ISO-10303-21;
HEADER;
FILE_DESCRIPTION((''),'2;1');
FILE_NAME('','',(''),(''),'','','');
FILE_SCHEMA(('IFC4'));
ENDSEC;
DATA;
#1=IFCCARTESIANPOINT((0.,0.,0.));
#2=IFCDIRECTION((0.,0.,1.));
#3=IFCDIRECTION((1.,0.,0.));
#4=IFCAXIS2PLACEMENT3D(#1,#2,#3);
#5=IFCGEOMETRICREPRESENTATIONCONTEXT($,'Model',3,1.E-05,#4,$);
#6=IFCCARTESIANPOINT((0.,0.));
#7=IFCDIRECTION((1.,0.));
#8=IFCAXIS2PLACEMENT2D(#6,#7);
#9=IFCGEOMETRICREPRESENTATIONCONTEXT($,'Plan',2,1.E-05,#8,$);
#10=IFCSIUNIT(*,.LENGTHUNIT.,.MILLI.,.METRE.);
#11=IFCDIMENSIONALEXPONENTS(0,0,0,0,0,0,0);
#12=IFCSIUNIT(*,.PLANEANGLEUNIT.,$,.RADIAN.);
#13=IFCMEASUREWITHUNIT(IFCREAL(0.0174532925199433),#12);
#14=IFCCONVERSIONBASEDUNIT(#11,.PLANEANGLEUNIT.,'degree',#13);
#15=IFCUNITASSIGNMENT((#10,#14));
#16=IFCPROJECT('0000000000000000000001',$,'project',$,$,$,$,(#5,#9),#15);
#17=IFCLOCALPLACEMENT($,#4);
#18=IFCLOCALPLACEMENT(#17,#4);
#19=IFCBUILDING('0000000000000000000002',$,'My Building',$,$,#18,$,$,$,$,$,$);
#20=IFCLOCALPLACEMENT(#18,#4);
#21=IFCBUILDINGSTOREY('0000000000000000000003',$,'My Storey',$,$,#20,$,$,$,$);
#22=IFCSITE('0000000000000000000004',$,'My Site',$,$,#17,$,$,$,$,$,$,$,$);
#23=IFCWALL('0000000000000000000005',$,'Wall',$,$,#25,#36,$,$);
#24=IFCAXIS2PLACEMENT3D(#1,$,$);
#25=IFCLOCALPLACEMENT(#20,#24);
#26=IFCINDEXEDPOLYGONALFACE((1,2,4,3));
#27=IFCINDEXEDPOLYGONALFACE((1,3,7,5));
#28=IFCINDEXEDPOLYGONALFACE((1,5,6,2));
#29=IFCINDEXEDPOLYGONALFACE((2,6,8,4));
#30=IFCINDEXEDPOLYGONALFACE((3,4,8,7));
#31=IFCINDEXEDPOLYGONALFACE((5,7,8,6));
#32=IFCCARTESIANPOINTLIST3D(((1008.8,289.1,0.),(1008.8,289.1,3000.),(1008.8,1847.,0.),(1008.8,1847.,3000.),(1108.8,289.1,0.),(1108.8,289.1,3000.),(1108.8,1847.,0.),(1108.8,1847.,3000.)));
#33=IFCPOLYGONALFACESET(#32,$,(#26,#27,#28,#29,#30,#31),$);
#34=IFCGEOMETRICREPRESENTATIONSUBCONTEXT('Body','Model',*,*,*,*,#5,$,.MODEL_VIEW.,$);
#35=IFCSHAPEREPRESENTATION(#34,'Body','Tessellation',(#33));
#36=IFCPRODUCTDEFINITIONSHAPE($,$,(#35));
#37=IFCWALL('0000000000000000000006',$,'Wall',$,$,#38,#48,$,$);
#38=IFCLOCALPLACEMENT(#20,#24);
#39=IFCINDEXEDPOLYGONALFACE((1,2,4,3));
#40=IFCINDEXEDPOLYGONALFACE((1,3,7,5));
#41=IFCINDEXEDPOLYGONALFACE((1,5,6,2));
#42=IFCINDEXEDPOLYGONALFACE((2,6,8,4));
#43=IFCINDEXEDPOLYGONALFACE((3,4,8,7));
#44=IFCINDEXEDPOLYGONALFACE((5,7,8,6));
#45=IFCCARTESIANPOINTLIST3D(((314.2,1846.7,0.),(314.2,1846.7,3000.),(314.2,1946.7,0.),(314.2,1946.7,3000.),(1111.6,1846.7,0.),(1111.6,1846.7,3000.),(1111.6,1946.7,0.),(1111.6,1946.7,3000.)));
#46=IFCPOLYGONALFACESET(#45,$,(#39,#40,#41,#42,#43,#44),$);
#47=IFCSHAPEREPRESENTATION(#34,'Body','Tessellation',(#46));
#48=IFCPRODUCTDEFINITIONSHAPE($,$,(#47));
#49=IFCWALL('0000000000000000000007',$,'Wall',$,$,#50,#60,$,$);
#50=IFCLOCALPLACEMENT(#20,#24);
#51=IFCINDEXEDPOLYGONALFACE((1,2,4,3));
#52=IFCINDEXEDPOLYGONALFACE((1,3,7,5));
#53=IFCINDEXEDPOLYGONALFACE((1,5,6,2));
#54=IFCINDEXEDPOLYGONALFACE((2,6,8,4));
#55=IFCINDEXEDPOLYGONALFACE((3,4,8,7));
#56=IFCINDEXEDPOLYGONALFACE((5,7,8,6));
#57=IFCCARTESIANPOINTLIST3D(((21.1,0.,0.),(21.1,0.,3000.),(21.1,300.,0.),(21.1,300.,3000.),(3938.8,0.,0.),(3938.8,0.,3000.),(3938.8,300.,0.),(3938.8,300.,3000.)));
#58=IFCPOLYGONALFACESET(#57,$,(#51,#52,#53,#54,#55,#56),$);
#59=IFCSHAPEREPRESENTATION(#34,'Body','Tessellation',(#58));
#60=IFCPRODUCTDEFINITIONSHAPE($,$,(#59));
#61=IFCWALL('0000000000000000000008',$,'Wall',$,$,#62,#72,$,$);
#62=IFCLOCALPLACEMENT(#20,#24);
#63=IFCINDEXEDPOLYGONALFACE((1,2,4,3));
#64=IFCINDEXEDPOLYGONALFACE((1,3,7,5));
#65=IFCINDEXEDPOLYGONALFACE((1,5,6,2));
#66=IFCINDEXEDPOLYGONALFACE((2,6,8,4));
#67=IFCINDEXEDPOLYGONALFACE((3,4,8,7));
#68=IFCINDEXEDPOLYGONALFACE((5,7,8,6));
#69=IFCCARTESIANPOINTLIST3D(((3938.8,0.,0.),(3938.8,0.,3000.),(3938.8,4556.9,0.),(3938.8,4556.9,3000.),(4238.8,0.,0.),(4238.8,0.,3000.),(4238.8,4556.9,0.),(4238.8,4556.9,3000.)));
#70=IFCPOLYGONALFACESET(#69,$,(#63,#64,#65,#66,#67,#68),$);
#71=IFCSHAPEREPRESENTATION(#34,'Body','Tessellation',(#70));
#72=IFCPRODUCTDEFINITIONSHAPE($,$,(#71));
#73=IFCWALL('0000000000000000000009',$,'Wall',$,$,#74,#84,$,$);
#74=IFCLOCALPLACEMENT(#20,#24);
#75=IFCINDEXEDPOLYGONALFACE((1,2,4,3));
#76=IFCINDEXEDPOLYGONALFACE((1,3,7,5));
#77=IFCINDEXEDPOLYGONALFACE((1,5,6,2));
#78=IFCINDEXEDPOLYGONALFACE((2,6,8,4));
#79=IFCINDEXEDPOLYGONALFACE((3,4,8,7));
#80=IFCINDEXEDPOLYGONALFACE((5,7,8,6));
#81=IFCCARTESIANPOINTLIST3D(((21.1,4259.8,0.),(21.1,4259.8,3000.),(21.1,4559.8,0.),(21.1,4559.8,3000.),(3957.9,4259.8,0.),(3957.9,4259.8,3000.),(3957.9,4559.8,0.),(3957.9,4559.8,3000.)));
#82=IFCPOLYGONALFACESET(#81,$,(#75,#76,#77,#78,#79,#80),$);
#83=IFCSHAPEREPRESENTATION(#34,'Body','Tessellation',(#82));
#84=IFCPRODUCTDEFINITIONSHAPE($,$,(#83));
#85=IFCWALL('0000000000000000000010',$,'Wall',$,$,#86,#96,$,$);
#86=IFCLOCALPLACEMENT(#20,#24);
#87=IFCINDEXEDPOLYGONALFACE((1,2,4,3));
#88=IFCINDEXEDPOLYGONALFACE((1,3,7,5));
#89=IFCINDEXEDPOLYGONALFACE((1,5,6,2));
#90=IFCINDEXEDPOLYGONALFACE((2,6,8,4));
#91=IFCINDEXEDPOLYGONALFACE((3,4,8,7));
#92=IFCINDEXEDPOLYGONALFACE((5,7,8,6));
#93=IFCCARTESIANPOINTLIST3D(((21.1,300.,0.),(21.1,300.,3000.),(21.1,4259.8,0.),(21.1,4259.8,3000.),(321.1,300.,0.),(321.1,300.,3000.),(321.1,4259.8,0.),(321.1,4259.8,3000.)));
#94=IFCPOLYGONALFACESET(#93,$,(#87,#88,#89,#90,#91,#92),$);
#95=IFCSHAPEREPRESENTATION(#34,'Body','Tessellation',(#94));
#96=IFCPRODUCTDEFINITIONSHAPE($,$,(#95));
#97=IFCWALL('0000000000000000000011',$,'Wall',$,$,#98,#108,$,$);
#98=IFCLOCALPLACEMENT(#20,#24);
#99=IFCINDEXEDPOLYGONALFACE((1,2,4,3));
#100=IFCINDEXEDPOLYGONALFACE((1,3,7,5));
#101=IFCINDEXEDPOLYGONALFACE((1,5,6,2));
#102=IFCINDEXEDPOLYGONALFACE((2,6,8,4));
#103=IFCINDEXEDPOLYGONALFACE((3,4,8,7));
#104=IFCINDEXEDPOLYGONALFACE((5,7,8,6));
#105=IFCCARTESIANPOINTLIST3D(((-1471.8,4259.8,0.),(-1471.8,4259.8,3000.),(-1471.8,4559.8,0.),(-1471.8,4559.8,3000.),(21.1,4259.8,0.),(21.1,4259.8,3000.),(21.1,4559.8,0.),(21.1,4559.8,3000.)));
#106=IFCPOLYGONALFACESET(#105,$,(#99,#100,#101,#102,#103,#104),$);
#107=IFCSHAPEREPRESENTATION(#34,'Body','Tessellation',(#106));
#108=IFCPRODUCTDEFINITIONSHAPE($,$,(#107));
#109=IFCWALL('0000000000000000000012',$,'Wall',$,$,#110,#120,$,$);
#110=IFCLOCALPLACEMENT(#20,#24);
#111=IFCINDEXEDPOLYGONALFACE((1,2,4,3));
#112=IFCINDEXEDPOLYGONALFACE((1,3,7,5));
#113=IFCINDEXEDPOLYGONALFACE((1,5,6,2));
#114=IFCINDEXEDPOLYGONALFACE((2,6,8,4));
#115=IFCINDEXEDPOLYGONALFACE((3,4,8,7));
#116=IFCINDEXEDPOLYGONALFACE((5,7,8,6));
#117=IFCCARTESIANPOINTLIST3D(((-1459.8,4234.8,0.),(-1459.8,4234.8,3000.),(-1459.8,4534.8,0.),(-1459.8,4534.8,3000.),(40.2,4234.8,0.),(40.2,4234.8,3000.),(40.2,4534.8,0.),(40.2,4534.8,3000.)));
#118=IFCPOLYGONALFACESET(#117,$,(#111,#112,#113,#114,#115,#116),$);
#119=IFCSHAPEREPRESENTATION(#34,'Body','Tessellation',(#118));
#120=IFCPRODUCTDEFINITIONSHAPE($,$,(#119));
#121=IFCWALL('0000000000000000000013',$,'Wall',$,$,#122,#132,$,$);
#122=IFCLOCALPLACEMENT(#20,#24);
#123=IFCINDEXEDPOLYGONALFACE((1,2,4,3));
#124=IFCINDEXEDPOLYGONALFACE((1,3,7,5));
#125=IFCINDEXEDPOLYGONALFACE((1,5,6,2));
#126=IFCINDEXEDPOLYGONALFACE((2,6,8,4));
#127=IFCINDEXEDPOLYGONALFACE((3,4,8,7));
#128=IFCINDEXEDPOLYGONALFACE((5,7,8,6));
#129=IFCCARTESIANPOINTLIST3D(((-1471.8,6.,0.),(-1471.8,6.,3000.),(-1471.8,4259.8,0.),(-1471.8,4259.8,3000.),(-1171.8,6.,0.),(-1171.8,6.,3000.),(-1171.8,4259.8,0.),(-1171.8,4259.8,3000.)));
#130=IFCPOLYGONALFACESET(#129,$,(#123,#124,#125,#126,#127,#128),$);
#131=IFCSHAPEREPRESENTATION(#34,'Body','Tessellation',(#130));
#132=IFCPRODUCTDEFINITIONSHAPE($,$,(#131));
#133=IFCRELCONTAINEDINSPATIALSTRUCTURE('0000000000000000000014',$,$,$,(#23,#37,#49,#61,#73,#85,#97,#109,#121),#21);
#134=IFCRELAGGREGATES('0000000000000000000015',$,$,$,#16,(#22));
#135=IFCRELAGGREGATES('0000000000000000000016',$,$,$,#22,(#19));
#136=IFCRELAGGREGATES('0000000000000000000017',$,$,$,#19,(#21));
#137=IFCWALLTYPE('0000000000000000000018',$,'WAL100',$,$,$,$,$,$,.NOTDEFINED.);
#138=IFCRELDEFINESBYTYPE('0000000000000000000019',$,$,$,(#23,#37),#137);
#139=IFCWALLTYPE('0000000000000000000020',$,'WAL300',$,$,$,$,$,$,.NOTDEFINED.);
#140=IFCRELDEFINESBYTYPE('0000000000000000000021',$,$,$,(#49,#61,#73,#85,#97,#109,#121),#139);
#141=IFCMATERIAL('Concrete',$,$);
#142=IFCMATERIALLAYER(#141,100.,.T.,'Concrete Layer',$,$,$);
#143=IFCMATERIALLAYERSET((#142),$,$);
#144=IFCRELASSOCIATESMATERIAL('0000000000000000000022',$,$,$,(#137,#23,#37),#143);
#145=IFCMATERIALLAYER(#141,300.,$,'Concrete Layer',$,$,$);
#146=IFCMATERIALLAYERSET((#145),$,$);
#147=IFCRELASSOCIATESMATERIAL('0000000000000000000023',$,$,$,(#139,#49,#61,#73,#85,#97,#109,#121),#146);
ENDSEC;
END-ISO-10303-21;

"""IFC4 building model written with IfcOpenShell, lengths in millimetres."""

from ifc_helpers import new_model, entity, si_unit, converted_unit, frame, origin_with_axes, origin_2d_with_axis, place, context, subcontext, project, spatial, indexed_curve, outline, extrude, material, layer, layer_set, layer_usage, type_object, element, save


model = new_model("IFC4")

# Units and contexts
model_context = context("Model", 3, precision=1e-05, world=origin_with_axes())
plan_context = context("Plan", 2, precision=1e-05, world=origin_2d_with_axis())
body_context = subcontext(model_context, "Body", "Model", "MODEL_VIEW")
ifc_project = project(units=[si_unit("LENGTHUNIT", "METRE", prefix="MILLI"), converted_unit("PLANEANGLEUNIT", "degree", entity("IfcReal", 0.0174532925199433), si_unit("PLANEANGLEUNIT", "RADIAN"), dimensions=[0, 0, 0, 0, 0, 0, 0])], contexts=[model_context, plan_context])

# Site, building, storey
site_placement = place(None, origin_with_axes())
site = spatial("IfcSite", under=ifc_project, at=site_placement, Name="My Site")
building_placement = place(site_placement, origin_with_axes())
building = spatial("IfcBuilding", under=site, at=building_placement, Name="My Building")
storey_placement = place(building_placement, origin_with_axes())
storey = spatial("IfcBuildingStorey", under=building, at=storey_placement, Name="My Storey")

# Walls
ifc_material = material(Name="Concrete")
ifc_layer_1 = layer(ifc_material, 100.0, ventilated=True, Name="Concrete Layer")
ifc_layer_set_1 = layer_set([ifc_layer_1])
ifc_layer_usage_1 = layer_usage(ifc_layer_set_1, "AXIS2", "POSITIVE", 0.0)
wall_type_1 = type_object("IfcWallType", Name="WAL100", PredefinedType="NOTDEFINED", material=ifc_layer_set_1)
wall_1_placement = place(storey_placement, frame((1108.8, 289.1, 0.0), z_axis=(0.0, 0.0, 1.0), x_axis=(0.0, 1.0, 0.0)))
element("IfcWall", 1, at=wall_1_placement, inside=storey, type_object=wall_type_1, material=ifc_layer_usage_1, Name="Wall", context=body_context, shape_type="SweptSolid", body=[
    extrude(outline(indexed_curve([(0.0, 0.0), (0.0, 100.0), (1557.9, 100.0), (1557.9, 0.0), (0.0, 0.0)], self_intersect=False)), origin_with_axes(), (0.0, 0.0, 1.0), 3000.0),
])
ifc_layer_usage_2 = layer_usage(ifc_layer_set_1, "AXIS2", "POSITIVE", 0.0)
wall_2_placement = place(storey_placement, frame((1111.6, 1946.7, 0.0), z_axis=(0.0, 0.0, 1.0), x_axis=(-1.0, 0.0, 0.0)))
element("IfcWall", 2, at=wall_2_placement, inside=storey, type_object=wall_type_1, material=ifc_layer_usage_2, Name="Wall", context=body_context, shape_type="SweptSolid", body=[
    extrude(outline(indexed_curve([(0.0, 0.0), (0.0, 100.0), (797.4, 100.0), (797.4, 0.0), (0.0, 0.0)], self_intersect=False)), origin_with_axes(), (0.0, 0.0, 1.0), 3000.0),
])
ifc_layer_2 = layer(ifc_material, 300.0, Name="Concrete Layer")
ifc_layer_set_2 = layer_set([ifc_layer_2])
ifc_layer_usage_3 = layer_usage(ifc_layer_set_2, "AXIS2", "POSITIVE", 0.0)
wall_type_2 = type_object("IfcWallType", Name="WAL300", PredefinedType="NOTDEFINED", material=ifc_layer_set_2)
wall_3_placement = place(storey_placement, frame((21.1, 0.0, 0.0), z_axis=(0.0, 0.0, 1.0), x_axis=(1.0, 0.0, 0.0)))
element("IfcWall", 3, at=wall_3_placement, inside=storey, type_object=wall_type_2, material=ifc_layer_usage_3, Name="Wall", context=body_context, shape_type="SweptSolid", body=[
    extrude(outline(indexed_curve([(0.0, 0.0), (0.0, 300.0), (3917.7, 300.0), (3917.7, 0.0), (0.0, 0.0)], self_intersect=False)), origin_with_axes(), (0.0, 0.0, 1.0), 3000.0),
])
ifc_layer_usage_4 = layer_usage(ifc_layer_set_2, "AXIS2", "POSITIVE", 0.0)
wall_4_placement = place(storey_placement, frame((4238.8, 0.0, 0.0), z_axis=(0.0, 0.0, 1.0), x_axis=(0.0, 1.0, 0.0)))
element("IfcWall", 4, at=wall_4_placement, inside=storey, type_object=wall_type_2, material=ifc_layer_usage_4, Name="Wall", context=body_context, shape_type="SweptSolid", body=[
    extrude(outline(indexed_curve([(0.0, 0.0), (0.0, 300.0), (4556.9, 300.0), (4556.9, 0.0), (0.0, 0.0)], self_intersect=False)), origin_with_axes(), (0.0, 0.0, 1.0), 3000.0),
])
ifc_layer_usage_5 = layer_usage(ifc_layer_set_2, "AXIS2", "POSITIVE", 0.0)
wall_5_placement = place(storey_placement, frame((3957.9, 4559.8, 0.0), z_axis=(0.0, 0.0, 1.0), x_axis=(-1.0, 0.0, 0.0)))
element("IfcWall", 5, at=wall_5_placement, inside=storey, type_object=wall_type_2, material=ifc_layer_usage_5, Name="Wall", context=body_context, shape_type="SweptSolid", body=[
    extrude(outline(indexed_curve([(0.0, 0.0), (0.0, 300.0), (3936.8, 300.0), (3936.8, 0.0), (0.0, 0.0)], self_intersect=False)), origin_with_axes(), (0.0, 0.0, 1.0), 3000.0),
])
ifc_layer_usage_6 = layer_usage(ifc_layer_set_2, "AXIS2", "POSITIVE", 0.0)
wall_6_placement = place(storey_placement, frame((21.1, 4259.8, 0.0), z_axis=(0.0, 0.0, 1.0), x_axis=(-0.000001, -1.0, 0.0)))
element("IfcWall", 6, at=wall_6_placement, inside=storey, type_object=wall_type_2, material=ifc_layer_usage_6, Name="Wall", context=body_context, shape_type="SweptSolid", body=[
    extrude(outline(indexed_curve([(0.0, 0.0), (0.0, 300.0), (3959.8, 300.0), (3959.8, 0.0), (0.0, 0.0)], self_intersect=False)), origin_with_axes(), (0.0, 0.0, 1.0), 3000.0),
])
ifc_layer_usage_7 = layer_usage(ifc_layer_set_2, "AXIS2", "POSITIVE", 0.0)
wall_7_placement = place(storey_placement, frame((21.1, 4559.8, 0.0), z_axis=(0.0, 0.0, 1.0), x_axis=(-1.0, 0.0, 0.0)))
element("IfcWall", 7, at=wall_7_placement, inside=storey, type_object=wall_type_2, material=ifc_layer_usage_7, Name="Wall", context=body_context, shape_type="SweptSolid", body=[
    extrude(outline(indexed_curve([(0.0, 0.0), (0.0, 300.0), (1492.9, 300.0), (1492.9, 0.0), (0.0, 0.0)], self_intersect=False)), origin_with_axes(), (0.0, 0.0, 1.0), 3000.0),
])
ifc_layer_usage_8 = layer_usage(ifc_layer_set_2, "AXIS2", "POSITIVE", 0.0)
wall_8_placement = place(storey_placement, frame((-1459.8, 4234.8, 0.0), z_axis=(0.0, 0.0, 1.0), x_axis=(1.0, 0.0, 0.0)))
element("IfcWall", 8, at=wall_8_placement, inside=storey, type_object=wall_type_2, material=ifc_layer_usage_8, Name="Wall", context=body_context, shape_type="SweptSolid", body=[
    extrude(outline(indexed_curve([(0.0, 0.0), (0.0, 300.0), (1500.0, 300.0), (1500.0, 0.0), (0.0, 0.0)], self_intersect=False)), origin_with_axes(), (0.0, 0.0, 1.0), 3000.0),
])
ifc_layer_usage_9 = layer_usage(ifc_layer_set_2, "AXIS2", "POSITIVE", 0.0)
wall_9_placement = place(storey_placement, frame((-1471.8, 4259.8, 0.0), z_axis=(0.0, 0.0, 1.0), x_axis=(0.0, -1.0, 0.0)))
element("IfcWall", 9, at=wall_9_placement, inside=storey, type_object=wall_type_2, material=ifc_layer_usage_9, Name="Wall", context=body_context, shape_type="SweptSolid", body=[
    extrude(outline(indexed_curve([(0.0, 0.0), (0.0, 300.0), (4253.8, 300.0), (4253.8, 0.0), (0.0, 0.0)], self_intersect=False)), origin_with_axes(), (0.0, 0.0, 1.0), 3000.0),
])

save(model, "model.ifc")
